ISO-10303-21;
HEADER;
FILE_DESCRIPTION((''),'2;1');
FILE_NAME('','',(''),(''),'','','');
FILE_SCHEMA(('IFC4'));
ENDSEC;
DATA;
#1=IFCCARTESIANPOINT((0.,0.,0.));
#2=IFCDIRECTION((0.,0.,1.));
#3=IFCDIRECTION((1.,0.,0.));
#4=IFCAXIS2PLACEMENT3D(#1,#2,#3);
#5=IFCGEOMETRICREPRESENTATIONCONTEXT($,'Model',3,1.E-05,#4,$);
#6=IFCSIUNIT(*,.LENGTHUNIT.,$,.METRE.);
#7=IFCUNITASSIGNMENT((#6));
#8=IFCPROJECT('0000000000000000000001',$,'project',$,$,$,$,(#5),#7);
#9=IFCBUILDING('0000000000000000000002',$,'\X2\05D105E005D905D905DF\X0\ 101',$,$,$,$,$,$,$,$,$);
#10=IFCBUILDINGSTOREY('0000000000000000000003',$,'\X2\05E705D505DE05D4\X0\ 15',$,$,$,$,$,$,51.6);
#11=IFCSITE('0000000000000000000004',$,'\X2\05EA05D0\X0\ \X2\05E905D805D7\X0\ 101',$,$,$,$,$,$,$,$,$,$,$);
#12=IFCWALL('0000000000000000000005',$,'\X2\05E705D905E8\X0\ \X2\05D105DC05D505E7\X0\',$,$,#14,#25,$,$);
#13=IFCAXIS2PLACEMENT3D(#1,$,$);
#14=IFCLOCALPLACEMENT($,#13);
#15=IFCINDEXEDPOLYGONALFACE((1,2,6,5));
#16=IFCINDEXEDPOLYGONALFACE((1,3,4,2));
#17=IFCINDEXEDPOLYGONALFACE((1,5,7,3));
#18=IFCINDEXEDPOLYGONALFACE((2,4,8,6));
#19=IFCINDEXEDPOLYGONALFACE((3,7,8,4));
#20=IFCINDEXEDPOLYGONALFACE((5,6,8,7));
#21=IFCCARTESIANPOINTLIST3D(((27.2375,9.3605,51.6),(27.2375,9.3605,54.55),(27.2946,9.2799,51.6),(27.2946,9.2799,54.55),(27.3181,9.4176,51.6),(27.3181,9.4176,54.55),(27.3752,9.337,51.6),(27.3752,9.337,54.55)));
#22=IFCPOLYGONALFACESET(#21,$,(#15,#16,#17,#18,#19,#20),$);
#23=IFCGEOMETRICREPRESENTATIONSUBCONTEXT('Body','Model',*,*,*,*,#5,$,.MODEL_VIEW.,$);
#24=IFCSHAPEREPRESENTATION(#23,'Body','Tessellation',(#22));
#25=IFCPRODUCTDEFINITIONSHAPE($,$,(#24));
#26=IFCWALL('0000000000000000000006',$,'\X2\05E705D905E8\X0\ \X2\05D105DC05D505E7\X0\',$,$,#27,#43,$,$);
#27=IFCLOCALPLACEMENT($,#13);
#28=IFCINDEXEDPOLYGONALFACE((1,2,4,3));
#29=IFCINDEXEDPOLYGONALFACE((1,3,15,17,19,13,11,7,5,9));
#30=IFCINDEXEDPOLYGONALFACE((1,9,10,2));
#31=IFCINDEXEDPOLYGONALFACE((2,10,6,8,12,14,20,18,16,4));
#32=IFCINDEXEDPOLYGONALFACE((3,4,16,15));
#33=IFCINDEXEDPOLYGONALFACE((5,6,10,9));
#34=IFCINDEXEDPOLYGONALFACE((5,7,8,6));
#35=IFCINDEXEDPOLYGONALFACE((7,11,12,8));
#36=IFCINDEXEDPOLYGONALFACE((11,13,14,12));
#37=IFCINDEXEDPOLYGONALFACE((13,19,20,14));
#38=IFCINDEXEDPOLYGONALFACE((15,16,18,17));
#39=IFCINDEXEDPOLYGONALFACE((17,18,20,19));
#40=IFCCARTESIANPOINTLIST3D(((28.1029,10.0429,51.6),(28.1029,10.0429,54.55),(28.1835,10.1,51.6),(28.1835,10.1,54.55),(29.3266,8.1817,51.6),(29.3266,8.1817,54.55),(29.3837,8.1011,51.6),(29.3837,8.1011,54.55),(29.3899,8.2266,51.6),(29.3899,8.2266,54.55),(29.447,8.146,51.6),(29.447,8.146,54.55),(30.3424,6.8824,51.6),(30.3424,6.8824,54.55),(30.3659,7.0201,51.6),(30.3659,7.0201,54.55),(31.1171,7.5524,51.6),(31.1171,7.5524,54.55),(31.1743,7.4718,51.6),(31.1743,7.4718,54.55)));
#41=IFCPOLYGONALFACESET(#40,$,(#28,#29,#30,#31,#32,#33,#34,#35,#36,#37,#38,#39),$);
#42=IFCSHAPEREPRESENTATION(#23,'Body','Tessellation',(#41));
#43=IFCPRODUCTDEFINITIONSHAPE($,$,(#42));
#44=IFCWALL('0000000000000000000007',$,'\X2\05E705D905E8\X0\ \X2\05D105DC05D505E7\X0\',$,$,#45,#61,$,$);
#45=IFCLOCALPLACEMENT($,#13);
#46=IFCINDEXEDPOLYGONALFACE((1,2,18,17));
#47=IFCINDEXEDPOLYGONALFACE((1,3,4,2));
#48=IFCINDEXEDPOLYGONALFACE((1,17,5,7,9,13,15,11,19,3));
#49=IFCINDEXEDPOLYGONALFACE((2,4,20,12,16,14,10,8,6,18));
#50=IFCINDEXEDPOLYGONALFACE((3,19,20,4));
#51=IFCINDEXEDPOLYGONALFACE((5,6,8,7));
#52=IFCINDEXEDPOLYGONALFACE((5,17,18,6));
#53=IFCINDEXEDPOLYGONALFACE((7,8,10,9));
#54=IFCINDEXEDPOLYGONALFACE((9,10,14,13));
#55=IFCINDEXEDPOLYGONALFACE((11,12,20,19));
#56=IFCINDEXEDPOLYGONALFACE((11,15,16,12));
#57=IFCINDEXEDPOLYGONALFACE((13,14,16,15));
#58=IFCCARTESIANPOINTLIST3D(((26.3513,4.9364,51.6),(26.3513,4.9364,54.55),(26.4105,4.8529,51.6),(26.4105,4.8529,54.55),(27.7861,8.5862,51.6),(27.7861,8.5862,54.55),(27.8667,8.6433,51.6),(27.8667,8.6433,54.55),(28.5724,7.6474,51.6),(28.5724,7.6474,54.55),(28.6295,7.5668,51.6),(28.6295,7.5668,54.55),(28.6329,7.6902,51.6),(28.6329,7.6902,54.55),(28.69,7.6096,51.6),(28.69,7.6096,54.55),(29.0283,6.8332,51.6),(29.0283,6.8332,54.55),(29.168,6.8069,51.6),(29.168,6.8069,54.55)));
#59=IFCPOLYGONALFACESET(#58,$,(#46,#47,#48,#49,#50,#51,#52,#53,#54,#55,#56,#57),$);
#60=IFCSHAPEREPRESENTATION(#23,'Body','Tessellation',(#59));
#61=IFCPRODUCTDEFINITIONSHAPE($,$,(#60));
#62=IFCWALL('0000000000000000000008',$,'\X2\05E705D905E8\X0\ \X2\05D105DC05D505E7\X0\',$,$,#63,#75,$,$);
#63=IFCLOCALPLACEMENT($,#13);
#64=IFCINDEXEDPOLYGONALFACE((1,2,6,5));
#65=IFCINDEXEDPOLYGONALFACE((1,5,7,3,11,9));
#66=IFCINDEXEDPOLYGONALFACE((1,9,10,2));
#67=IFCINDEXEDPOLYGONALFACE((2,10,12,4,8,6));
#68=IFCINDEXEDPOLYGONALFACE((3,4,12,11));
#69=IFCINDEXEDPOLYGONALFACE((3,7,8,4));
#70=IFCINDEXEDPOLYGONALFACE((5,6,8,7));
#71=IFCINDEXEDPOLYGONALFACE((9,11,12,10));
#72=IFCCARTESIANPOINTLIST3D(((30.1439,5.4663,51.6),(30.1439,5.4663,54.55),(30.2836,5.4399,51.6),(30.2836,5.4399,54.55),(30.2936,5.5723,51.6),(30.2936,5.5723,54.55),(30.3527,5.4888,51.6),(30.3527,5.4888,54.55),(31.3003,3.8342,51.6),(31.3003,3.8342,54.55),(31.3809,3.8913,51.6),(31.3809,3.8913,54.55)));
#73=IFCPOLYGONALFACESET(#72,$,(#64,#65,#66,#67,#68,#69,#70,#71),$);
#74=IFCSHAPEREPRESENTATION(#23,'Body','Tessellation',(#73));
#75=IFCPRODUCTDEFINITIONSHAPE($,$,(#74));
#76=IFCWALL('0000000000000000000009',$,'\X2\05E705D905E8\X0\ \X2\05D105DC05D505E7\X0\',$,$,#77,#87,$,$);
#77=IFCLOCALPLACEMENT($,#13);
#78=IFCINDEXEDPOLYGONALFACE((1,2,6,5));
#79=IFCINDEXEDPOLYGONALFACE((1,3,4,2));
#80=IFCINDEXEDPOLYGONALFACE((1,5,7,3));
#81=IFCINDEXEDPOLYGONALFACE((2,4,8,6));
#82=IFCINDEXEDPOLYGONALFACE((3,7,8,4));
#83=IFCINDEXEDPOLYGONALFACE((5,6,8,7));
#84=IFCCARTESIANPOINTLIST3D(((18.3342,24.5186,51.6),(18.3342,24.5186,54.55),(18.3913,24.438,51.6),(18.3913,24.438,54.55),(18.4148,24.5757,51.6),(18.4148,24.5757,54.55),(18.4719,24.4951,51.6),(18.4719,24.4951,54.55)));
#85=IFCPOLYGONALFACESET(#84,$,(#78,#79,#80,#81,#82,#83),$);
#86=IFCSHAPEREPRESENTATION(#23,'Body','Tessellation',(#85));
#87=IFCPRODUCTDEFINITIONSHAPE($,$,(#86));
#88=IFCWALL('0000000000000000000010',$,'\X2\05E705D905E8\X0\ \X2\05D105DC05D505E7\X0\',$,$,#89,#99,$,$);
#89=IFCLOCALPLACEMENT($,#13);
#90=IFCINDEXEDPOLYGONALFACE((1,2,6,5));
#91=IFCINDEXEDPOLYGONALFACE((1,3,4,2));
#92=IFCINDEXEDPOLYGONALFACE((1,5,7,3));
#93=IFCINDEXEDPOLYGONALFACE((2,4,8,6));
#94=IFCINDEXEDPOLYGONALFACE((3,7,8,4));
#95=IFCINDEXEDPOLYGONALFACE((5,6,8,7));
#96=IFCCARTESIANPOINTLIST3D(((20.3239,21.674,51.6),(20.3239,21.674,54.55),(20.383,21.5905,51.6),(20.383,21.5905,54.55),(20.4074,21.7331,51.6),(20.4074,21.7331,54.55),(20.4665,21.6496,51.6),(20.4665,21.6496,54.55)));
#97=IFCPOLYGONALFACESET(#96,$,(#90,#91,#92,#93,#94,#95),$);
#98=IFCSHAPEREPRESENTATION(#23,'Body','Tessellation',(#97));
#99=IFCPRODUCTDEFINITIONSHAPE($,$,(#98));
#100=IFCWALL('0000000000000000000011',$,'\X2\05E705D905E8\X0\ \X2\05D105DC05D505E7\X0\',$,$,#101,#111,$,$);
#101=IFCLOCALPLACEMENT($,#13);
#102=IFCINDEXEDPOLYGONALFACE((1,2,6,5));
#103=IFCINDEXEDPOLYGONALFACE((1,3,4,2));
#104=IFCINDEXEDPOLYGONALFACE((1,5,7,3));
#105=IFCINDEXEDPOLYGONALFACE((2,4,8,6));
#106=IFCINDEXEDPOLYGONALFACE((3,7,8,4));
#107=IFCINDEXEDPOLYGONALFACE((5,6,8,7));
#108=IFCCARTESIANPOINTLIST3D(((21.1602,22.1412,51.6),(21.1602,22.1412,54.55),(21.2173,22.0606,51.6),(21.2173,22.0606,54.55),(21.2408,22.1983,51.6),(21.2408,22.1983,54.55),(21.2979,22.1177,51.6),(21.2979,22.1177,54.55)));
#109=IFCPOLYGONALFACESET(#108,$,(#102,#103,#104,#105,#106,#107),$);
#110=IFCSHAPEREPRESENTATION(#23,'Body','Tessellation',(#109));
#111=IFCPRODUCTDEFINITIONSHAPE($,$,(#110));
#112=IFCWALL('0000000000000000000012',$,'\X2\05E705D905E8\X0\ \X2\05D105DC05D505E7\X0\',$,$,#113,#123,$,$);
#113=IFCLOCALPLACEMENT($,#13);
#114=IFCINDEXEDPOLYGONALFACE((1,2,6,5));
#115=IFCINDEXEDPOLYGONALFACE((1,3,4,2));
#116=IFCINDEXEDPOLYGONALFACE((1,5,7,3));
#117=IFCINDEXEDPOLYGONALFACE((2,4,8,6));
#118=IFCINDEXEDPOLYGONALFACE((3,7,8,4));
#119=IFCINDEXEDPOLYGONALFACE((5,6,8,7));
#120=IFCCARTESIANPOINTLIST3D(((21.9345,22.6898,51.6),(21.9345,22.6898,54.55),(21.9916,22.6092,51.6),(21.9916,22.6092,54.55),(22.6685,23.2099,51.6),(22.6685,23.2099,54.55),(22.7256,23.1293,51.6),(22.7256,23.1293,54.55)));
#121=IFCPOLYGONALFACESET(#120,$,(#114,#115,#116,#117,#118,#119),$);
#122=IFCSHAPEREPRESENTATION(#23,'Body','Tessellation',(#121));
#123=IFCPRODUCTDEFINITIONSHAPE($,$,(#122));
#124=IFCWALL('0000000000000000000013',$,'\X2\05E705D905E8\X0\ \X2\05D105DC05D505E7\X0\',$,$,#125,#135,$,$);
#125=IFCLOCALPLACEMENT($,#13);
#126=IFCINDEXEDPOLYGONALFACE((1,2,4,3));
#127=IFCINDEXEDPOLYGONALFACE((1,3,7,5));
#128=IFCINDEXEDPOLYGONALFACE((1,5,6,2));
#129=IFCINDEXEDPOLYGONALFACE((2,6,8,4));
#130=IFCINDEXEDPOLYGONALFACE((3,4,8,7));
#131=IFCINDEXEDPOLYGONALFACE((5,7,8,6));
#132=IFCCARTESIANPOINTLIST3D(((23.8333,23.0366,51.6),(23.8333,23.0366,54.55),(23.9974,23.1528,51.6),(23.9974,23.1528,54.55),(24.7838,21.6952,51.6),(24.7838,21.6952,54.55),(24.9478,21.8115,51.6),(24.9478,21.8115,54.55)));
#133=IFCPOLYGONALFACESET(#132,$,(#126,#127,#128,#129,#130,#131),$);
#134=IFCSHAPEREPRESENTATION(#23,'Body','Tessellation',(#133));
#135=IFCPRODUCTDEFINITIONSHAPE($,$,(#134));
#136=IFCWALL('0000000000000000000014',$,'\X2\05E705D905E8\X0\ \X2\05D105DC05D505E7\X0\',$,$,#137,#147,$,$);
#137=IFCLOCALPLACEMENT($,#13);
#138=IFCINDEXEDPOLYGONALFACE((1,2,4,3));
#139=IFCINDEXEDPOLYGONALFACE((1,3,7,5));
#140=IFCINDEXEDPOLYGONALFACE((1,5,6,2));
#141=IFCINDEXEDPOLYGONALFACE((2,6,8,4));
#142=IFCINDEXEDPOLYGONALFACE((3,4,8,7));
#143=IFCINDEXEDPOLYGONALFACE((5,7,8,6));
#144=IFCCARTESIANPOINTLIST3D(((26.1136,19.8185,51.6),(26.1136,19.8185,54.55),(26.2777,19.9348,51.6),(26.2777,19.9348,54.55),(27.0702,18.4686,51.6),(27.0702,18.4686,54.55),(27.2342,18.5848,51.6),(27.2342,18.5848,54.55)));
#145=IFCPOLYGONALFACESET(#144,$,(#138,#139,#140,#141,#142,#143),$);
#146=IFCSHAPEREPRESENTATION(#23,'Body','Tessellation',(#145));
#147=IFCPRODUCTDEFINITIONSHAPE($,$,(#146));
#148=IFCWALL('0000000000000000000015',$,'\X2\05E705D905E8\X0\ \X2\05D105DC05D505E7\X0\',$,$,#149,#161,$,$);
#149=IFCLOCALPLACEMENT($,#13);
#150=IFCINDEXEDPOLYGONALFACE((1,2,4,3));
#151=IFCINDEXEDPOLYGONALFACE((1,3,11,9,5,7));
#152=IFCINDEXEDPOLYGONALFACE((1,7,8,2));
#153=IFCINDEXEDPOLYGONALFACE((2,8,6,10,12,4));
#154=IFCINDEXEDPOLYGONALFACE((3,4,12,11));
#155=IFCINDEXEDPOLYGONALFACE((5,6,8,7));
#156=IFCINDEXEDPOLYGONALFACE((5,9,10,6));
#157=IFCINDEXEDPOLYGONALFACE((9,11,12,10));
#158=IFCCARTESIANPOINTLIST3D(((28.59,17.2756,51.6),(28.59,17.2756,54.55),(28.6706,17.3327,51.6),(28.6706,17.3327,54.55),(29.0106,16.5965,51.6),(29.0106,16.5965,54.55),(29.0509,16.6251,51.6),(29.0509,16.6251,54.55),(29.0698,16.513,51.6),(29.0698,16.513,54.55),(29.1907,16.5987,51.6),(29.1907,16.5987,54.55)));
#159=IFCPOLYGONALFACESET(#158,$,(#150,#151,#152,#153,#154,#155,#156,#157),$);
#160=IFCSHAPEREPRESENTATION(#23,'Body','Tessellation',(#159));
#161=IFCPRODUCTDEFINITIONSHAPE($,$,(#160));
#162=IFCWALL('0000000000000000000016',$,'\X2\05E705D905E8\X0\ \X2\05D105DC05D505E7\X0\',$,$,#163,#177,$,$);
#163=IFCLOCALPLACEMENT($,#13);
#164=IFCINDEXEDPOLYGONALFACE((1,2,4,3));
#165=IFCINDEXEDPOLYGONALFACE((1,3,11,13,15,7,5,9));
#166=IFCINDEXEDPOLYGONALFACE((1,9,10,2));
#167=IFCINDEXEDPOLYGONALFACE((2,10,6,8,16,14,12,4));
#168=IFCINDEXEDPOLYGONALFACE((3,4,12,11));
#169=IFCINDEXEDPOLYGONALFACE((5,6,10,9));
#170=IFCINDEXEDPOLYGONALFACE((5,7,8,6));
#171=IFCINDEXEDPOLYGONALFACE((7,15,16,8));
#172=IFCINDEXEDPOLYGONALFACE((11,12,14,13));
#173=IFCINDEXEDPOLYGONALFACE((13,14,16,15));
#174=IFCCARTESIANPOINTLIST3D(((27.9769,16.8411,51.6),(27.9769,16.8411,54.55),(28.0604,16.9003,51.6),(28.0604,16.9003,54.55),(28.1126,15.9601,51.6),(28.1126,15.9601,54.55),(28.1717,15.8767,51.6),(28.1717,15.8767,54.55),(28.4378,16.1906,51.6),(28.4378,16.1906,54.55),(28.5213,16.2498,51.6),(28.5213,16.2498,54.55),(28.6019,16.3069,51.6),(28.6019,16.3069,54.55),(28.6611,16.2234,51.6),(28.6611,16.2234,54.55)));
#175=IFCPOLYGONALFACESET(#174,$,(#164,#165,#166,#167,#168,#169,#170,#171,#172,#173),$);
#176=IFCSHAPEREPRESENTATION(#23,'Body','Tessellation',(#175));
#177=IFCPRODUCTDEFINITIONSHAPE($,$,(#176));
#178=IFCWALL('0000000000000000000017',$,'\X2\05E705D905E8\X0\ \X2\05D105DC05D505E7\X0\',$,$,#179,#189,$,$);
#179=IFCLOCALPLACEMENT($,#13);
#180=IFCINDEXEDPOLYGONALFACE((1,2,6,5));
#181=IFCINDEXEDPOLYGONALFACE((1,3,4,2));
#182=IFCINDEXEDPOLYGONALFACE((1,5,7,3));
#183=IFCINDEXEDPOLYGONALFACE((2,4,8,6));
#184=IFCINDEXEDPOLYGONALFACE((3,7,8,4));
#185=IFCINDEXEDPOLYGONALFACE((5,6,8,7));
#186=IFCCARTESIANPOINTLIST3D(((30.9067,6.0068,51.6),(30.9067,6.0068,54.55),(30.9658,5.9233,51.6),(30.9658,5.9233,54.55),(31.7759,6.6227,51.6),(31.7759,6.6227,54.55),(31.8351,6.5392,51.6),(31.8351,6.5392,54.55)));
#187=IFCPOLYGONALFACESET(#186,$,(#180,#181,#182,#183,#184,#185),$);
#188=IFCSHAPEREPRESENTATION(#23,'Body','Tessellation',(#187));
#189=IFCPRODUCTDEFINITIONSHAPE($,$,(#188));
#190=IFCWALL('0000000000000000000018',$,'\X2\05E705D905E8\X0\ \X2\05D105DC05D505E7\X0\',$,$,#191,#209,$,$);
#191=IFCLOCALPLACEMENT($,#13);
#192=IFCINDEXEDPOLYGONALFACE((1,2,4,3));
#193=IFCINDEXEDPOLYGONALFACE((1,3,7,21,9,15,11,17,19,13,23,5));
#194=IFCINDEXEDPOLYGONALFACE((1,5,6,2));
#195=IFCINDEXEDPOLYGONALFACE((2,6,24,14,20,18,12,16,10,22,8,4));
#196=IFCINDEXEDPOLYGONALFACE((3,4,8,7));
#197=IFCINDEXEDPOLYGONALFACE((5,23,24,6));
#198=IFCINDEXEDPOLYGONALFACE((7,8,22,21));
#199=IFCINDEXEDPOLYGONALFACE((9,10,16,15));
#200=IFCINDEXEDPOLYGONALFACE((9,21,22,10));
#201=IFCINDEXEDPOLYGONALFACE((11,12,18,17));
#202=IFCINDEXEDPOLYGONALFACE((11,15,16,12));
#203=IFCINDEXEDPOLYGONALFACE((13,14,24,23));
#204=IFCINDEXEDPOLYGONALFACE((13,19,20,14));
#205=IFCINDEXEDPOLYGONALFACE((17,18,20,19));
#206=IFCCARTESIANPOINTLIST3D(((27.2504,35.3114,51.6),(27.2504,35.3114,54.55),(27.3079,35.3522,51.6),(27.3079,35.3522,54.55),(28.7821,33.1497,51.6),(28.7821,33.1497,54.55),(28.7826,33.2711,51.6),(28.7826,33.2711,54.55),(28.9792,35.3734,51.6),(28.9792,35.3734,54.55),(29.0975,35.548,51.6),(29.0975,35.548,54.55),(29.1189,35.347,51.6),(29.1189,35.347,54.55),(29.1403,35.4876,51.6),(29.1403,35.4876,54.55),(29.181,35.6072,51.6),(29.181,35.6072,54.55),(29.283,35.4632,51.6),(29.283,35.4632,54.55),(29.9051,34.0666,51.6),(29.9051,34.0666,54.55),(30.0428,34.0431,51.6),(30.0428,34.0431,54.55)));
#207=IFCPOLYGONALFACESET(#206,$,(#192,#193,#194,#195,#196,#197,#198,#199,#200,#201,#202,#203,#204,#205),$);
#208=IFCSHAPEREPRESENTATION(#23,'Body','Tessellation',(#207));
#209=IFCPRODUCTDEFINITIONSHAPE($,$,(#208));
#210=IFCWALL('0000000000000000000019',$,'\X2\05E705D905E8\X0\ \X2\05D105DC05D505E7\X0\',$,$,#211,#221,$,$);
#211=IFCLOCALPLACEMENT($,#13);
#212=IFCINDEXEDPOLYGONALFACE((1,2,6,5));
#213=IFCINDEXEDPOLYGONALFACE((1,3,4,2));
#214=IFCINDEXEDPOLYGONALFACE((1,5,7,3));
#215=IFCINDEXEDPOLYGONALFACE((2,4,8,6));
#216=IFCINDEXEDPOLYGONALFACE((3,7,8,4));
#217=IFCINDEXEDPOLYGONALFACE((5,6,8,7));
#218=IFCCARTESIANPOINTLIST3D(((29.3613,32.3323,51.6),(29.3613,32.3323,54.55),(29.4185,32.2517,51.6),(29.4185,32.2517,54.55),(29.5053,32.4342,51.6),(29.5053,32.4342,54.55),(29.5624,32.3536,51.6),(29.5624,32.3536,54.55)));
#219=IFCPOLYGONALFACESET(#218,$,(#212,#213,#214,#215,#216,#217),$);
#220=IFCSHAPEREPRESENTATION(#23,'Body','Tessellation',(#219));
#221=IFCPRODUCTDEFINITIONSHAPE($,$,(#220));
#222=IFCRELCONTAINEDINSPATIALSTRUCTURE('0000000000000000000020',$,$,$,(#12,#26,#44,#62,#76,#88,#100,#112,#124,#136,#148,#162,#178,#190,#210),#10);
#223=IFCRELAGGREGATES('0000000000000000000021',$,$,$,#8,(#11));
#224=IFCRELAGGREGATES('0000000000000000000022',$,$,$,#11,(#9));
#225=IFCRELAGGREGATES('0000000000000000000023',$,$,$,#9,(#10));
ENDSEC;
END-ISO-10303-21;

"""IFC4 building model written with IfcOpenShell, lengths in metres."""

from ifc_helpers import new_model, si_unit, frame, origin_with_axes, context, subcontext, project, spatial, polyline, outline, extrude, element, save


model = new_model("IFC4")

# Units and contexts
model_context = context("Model", 3, precision=1e-05, world=origin_with_axes())
body_context = subcontext(model_context, "Body", "Model", "MODEL_VIEW")
ifc_project = project(units=[si_unit("LENGTHUNIT", "METRE")], contexts=[model_context])

# Site, building, storey
site = spatial("IfcSite", under=ifc_project, Name="תא שטח 101")
building = spatial("IfcBuilding", under=site, Name="בניין 101")
storey = spatial("IfcBuildingStorey", under=building, Name="קומה 15", Elevation=51.6)

# Walls
element("IfcWall", 1, inside=storey, Name="קיר בלוק", context=body_context, shape_type="SweptSolid", body=[
    extrude(outline(polyline([(27.3181, 9.4176), (27.2375, 9.3605), (27.2946, 9.2799), (27.3752, 9.337), (27.3181, 9.4176)])), frame((0.0, 0.0, 51.6)), (0.0, 0.0, 1.0), 2.95),
])
element("IfcWall", 2, inside=storey, Name="קיר בלוק", context=body_context, shape_type="SweptSolid", body=[
    extrude(outline(polyline([(29.3266, 8.1817), (29.3837, 8.1011), (29.447, 8.146), (30.3424, 6.8824), (31.1743, 7.4718), (31.1171, 7.5524), (30.3659, 7.0201), (28.1835, 10.1), (28.1029, 10.0429), (29.3899, 8.2266), (29.3266, 8.1817)])), frame((0.0, 0.0, 51.6)), (0.0, 0.0, 1.0), 2.95),
])
element("IfcWall", 3, inside=storey, Name="קיר בלוק", context=body_context, shape_type="SweptSolid", body=[
    extrude(outline(polyline([(26.4105, 4.8529), (29.168, 6.8069), (28.6295, 7.5668), (28.69, 7.6096), (28.6329, 7.6902), (28.5724, 7.6474), (27.8667, 8.6433), (27.7861, 8.5862), (29.0283, 6.8332), (26.3513, 4.9364), (26.4105, 4.8529)])), frame((0.0, 0.0, 51.6)), (0.0, 0.0, 1.0), 2.95),
])
element("IfcWall", 4, inside=storey, Name="קיר בלוק", context=body_context, shape_type="SweptSolid", body=[
    extrude(outline(polyline([(30.2836, 5.4399), (30.3527, 5.4888), (30.2936, 5.5723), (30.1439, 5.4663), (31.3003, 3.8342), (31.3809, 3.8913), (30.2836, 5.4399)])), frame((0.0, 0.0, 51.6)), (0.0, 0.0, 1.0), 2.95),
])
element("IfcWall", 5, inside=storey, Name="קיר בלוק", context=body_context, shape_type="SweptSolid", body=[
    extrude(outline(polyline([(18.3913, 24.438), (18.4719, 24.4951), (18.4148, 24.5757), (18.3342, 24.5186), (18.3913, 24.438)])), frame((0.0, 0.0, 51.6)), (0.0, 0.0, 1.0), 2.95),
])
element("IfcWall", 6, inside=storey, Name="קיר בלוק", context=body_context, shape_type="SweptSolid", body=[
    extrude(outline(polyline([(20.4074, 21.7331), (20.3239, 21.674), (20.383, 21.5905), (20.4665, 21.6496), (20.4074, 21.7331)])), frame((0.0, 0.0, 51.6)), (0.0, 0.0, 1.0), 2.95),
])
element("IfcWall", 7, inside=storey, Name="קיר בלוק", context=body_context, shape_type="SweptSolid", body=[
    extrude(outline(polyline([(21.2979, 22.1177), (21.2408, 22.1983), (21.1602, 22.1412), (21.2173, 22.0606), (21.2979, 22.1177)])), frame((0.0, 0.0, 51.6)), (0.0, 0.0, 1.0), 2.95),
])
element("IfcWall", 8, inside=storey, Name="קיר בלוק", context=body_context, shape_type="SweptSolid", body=[
    extrude(outline(polyline([(22.7256, 23.1293), (22.6685, 23.2099), (21.9345, 22.6898), (21.9916, 22.6092), (22.7256, 23.1293)])), frame((0.0, 0.0, 51.6)), (0.0, 0.0, 1.0), 2.95),
])
element("IfcWall", 9, inside=storey, Name="קיר בלוק", context=body_context, shape_type="SweptSolid", body=[
    extrude(outline(polyline([(23.9974, 23.1528), (23.8333, 23.0366), (24.7838, 21.6952), (24.9478, 21.8115), (23.9974, 23.1528)])), frame((0.0, 0.0, 51.6)), (0.0, 0.0, 1.0), 2.95),
])
element("IfcWall", 10, inside=storey, Name="קיר בלוק", context=body_context, shape_type="SweptSolid", body=[
    extrude(outline(polyline([(27.0702, 18.4686), (27.2342, 18.5848), (26.2777, 19.9348), (26.1136, 19.8185), (27.0702, 18.4686)])), frame((0.0, 0.0, 51.6)), (0.0, 0.0, 1.0), 2.95),
])
element("IfcWall", 11, inside=storey, Name="קיר בלוק", context=body_context, shape_type="SweptSolid", body=[
    extrude(outline(polyline([(29.0106, 16.5965), (29.0698, 16.513), (29.1907, 16.5987), (28.6706, 17.3327), (28.59, 17.2756), (29.0509, 16.6251), (29.0106, 16.5965)])), frame((0.0, 0.0, 51.6)), (0.0, 0.0, 1.0), 2.95),
])
element("IfcWall", 12, inside=storey, Name="קיר בלוק", context=body_context, shape_type="SweptSolid", body=[
    extrude(outline(polyline([(28.1717, 15.8767), (28.6611, 16.2234), (28.6019, 16.3069), (28.5213, 16.2498), (28.0604, 16.9003), (27.9769, 16.8411), (28.4378, 16.1906), (28.1126, 15.9601), (28.1717, 15.8767)])), frame((0.0, 0.0, 51.6)), (0.0, 0.0, 1.0), 2.95),
])
element("IfcWall", 13, inside=storey, Name="קיר בלוק", context=body_context, shape_type="SweptSolid", body=[
    extrude(outline(polyline([(31.7759, 6.6227), (30.9067, 6.0068), (30.9658, 5.9233), (31.8351, 6.5392), (31.7759, 6.6227)])), frame((0.0, 0.0, 51.6)), (0.0, 0.0, 1.0), 2.95),
])
element("IfcWall", 14, inside=storey, Name="קיר בלוק", context=body_context, shape_type="SweptSolid", body=[
    extrude(outline(polyline([(27.2504, 35.3114), (28.7821, 33.1497), (30.0428, 34.0431), (29.1189, 35.347), (29.283, 35.4632), (29.181, 35.6072), (29.0975, 35.548), (29.1403, 35.4876), (28.9792, 35.3734), (29.9051, 34.0666), (28.7826, 33.2711), (27.3079, 35.3522), (27.2504, 35.3114)])), frame((0.0, 0.0, 51.6)), (0.0, 0.0, 1.0), 2.95),
])
element("IfcWall", 15, inside=storey, Name="קיר בלוק", context=body_context, shape_type="SweptSolid", body=[
    extrude(outline(polyline([(29.3613, 32.3323), (29.4185, 32.2517), (29.5624, 32.3536), (29.5053, 32.4342), (29.3613, 32.3323)])), frame((0.0, 0.0, 51.6)), (0.0, 0.0, 1.0), 2.95),
])

save(model, "model.ifc")
